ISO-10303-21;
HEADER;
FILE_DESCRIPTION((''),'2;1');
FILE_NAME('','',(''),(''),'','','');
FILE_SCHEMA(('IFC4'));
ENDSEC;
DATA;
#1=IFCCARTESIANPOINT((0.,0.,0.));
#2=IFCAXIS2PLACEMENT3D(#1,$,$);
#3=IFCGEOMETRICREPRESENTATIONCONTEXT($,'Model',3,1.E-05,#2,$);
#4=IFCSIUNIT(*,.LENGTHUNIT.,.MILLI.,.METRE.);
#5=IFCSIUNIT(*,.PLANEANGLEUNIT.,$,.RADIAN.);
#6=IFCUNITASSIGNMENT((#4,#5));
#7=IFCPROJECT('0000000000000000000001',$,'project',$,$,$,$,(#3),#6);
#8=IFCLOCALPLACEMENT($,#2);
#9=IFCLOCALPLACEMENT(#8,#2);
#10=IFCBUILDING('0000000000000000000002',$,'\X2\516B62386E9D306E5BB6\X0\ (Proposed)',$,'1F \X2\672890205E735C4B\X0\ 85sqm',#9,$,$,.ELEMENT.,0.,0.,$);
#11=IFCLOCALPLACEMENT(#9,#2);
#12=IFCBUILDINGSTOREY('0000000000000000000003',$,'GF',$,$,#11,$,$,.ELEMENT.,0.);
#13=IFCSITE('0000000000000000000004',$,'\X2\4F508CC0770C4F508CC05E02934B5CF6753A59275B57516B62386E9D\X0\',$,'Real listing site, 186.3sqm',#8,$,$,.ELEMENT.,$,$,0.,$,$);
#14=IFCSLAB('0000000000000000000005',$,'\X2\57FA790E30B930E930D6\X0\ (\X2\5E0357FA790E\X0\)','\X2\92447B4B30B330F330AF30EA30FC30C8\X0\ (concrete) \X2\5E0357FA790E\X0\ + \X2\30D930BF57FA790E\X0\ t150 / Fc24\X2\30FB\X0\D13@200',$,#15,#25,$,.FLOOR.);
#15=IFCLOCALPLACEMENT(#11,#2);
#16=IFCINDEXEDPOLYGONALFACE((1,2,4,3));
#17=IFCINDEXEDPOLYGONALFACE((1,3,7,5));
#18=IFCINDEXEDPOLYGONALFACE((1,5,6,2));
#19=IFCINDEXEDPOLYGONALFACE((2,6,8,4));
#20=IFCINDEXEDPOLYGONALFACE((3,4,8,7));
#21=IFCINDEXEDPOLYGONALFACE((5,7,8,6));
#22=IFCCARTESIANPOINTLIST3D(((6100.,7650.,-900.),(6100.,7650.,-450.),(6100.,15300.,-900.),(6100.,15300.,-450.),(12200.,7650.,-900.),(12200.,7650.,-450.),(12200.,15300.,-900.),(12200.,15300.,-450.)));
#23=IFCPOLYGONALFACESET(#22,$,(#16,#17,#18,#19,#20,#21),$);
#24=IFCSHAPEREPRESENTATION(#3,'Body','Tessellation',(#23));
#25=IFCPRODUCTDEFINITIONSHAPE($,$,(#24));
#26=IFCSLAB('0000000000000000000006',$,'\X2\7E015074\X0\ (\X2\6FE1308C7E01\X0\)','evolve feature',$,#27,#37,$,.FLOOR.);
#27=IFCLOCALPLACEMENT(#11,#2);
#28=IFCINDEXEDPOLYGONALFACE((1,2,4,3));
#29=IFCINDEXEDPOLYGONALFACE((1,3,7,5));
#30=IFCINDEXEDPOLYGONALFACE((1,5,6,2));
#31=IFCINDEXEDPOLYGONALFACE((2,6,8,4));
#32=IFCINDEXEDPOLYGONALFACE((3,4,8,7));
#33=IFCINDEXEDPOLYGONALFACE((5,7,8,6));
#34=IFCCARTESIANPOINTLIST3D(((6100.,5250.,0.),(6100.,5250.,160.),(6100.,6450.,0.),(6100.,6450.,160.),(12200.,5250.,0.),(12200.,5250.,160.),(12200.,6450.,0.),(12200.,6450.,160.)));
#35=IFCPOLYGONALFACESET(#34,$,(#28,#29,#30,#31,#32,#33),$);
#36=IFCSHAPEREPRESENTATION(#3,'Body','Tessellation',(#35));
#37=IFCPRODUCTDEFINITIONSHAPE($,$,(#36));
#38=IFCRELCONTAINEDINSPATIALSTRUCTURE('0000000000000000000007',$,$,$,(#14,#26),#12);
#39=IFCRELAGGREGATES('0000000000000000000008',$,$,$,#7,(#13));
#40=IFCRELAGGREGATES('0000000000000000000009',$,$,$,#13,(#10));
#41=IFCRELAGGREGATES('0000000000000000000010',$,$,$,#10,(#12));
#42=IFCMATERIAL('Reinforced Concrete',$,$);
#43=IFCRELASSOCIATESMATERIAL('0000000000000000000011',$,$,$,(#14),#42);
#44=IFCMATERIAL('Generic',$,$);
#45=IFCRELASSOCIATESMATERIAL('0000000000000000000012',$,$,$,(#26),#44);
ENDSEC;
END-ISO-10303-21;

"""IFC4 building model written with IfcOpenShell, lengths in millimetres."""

from ifc_helpers import new_model, si_unit, frame, frame_2d, origin, place, context, project, spatial, rectangle, extrude, material, element, save


model = new_model("IFC4")

# Units and contexts
model_context = context("Model", 3, precision=1e-05, world=origin())
ifc_project = project(units=[si_unit("LENGTHUNIT", "METRE", prefix="MILLI"), si_unit("PLANEANGLEUNIT", "RADIAN")], contexts=[model_context])

# Site, building, storey
site_placement = place(None, origin())
site = spatial("IfcSite", under=ifc_project, at=site_placement, Name="佐賀県佐賀市鍋島町大字八戸溝", ObjectType="Real listing site, 186.3sqm", CompositionType="ELEMENT", RefElevation=0.0)
building_placement = place(site_placement, origin())
building = spatial("IfcBuilding", under=site, at=building_placement, Name="八戸溝の家 (Proposed)", ObjectType="1F 木造平屋 85sqm", CompositionType="ELEMENT", ElevationOfRefHeight=0.0, ElevationOfTerrain=0.0)
storey_placement = place(building_placement, origin())
storey = spatial("IfcBuildingStorey", under=building, at=storey_placement, Name="GF", CompositionType="ELEMENT", Elevation=0.0)

# Slabs
ifc_material_1 = material(Name="Reinforced Concrete")
slab_1_placement = place(storey_placement, frame((3050.0, 3825.0, -450.0)))
element("IfcSlab", 1, at=slab_1_placement, inside=storey, material=ifc_material_1, Name="基礎スラブ (布基礎)", Description="鉄筋コンクリート (concrete) 布基礎 + ベタ基礎 t150 / Fc24・D13@200", PredefinedType="FLOOR", context=model_context, shape_type="SweptSolid", body=[
    extrude(rectangle(XDim=6100.0, YDim=7650.0, at=frame_2d((3050.0, 3825.0))), frame((3050.0, 3825.0, -450.0)), (0.0, 0.0, 1.0), 450.0),
])
ifc_material_2 = material(Name="Generic")
slab_2_placement = place(storey_placement, frame((3050.0, 2625.0, 0.0)))
element("IfcSlab", 2, at=slab_2_placement, inside=storey, material=ifc_material_2, Name="縁側 (濡れ縁)", Description="evolve feature", PredefinedType="FLOOR", context=model_context, shape_type="SweptSolid", body=[
    extrude(rectangle(XDim=6100.0, YDim=1200.0, at=frame_2d((3050.0, 600.0))), frame((3050.0, 2625.0, 0.0)), (0.0, 0.0, 1.0), 160.0),
])

save(model, "model.ifc")
